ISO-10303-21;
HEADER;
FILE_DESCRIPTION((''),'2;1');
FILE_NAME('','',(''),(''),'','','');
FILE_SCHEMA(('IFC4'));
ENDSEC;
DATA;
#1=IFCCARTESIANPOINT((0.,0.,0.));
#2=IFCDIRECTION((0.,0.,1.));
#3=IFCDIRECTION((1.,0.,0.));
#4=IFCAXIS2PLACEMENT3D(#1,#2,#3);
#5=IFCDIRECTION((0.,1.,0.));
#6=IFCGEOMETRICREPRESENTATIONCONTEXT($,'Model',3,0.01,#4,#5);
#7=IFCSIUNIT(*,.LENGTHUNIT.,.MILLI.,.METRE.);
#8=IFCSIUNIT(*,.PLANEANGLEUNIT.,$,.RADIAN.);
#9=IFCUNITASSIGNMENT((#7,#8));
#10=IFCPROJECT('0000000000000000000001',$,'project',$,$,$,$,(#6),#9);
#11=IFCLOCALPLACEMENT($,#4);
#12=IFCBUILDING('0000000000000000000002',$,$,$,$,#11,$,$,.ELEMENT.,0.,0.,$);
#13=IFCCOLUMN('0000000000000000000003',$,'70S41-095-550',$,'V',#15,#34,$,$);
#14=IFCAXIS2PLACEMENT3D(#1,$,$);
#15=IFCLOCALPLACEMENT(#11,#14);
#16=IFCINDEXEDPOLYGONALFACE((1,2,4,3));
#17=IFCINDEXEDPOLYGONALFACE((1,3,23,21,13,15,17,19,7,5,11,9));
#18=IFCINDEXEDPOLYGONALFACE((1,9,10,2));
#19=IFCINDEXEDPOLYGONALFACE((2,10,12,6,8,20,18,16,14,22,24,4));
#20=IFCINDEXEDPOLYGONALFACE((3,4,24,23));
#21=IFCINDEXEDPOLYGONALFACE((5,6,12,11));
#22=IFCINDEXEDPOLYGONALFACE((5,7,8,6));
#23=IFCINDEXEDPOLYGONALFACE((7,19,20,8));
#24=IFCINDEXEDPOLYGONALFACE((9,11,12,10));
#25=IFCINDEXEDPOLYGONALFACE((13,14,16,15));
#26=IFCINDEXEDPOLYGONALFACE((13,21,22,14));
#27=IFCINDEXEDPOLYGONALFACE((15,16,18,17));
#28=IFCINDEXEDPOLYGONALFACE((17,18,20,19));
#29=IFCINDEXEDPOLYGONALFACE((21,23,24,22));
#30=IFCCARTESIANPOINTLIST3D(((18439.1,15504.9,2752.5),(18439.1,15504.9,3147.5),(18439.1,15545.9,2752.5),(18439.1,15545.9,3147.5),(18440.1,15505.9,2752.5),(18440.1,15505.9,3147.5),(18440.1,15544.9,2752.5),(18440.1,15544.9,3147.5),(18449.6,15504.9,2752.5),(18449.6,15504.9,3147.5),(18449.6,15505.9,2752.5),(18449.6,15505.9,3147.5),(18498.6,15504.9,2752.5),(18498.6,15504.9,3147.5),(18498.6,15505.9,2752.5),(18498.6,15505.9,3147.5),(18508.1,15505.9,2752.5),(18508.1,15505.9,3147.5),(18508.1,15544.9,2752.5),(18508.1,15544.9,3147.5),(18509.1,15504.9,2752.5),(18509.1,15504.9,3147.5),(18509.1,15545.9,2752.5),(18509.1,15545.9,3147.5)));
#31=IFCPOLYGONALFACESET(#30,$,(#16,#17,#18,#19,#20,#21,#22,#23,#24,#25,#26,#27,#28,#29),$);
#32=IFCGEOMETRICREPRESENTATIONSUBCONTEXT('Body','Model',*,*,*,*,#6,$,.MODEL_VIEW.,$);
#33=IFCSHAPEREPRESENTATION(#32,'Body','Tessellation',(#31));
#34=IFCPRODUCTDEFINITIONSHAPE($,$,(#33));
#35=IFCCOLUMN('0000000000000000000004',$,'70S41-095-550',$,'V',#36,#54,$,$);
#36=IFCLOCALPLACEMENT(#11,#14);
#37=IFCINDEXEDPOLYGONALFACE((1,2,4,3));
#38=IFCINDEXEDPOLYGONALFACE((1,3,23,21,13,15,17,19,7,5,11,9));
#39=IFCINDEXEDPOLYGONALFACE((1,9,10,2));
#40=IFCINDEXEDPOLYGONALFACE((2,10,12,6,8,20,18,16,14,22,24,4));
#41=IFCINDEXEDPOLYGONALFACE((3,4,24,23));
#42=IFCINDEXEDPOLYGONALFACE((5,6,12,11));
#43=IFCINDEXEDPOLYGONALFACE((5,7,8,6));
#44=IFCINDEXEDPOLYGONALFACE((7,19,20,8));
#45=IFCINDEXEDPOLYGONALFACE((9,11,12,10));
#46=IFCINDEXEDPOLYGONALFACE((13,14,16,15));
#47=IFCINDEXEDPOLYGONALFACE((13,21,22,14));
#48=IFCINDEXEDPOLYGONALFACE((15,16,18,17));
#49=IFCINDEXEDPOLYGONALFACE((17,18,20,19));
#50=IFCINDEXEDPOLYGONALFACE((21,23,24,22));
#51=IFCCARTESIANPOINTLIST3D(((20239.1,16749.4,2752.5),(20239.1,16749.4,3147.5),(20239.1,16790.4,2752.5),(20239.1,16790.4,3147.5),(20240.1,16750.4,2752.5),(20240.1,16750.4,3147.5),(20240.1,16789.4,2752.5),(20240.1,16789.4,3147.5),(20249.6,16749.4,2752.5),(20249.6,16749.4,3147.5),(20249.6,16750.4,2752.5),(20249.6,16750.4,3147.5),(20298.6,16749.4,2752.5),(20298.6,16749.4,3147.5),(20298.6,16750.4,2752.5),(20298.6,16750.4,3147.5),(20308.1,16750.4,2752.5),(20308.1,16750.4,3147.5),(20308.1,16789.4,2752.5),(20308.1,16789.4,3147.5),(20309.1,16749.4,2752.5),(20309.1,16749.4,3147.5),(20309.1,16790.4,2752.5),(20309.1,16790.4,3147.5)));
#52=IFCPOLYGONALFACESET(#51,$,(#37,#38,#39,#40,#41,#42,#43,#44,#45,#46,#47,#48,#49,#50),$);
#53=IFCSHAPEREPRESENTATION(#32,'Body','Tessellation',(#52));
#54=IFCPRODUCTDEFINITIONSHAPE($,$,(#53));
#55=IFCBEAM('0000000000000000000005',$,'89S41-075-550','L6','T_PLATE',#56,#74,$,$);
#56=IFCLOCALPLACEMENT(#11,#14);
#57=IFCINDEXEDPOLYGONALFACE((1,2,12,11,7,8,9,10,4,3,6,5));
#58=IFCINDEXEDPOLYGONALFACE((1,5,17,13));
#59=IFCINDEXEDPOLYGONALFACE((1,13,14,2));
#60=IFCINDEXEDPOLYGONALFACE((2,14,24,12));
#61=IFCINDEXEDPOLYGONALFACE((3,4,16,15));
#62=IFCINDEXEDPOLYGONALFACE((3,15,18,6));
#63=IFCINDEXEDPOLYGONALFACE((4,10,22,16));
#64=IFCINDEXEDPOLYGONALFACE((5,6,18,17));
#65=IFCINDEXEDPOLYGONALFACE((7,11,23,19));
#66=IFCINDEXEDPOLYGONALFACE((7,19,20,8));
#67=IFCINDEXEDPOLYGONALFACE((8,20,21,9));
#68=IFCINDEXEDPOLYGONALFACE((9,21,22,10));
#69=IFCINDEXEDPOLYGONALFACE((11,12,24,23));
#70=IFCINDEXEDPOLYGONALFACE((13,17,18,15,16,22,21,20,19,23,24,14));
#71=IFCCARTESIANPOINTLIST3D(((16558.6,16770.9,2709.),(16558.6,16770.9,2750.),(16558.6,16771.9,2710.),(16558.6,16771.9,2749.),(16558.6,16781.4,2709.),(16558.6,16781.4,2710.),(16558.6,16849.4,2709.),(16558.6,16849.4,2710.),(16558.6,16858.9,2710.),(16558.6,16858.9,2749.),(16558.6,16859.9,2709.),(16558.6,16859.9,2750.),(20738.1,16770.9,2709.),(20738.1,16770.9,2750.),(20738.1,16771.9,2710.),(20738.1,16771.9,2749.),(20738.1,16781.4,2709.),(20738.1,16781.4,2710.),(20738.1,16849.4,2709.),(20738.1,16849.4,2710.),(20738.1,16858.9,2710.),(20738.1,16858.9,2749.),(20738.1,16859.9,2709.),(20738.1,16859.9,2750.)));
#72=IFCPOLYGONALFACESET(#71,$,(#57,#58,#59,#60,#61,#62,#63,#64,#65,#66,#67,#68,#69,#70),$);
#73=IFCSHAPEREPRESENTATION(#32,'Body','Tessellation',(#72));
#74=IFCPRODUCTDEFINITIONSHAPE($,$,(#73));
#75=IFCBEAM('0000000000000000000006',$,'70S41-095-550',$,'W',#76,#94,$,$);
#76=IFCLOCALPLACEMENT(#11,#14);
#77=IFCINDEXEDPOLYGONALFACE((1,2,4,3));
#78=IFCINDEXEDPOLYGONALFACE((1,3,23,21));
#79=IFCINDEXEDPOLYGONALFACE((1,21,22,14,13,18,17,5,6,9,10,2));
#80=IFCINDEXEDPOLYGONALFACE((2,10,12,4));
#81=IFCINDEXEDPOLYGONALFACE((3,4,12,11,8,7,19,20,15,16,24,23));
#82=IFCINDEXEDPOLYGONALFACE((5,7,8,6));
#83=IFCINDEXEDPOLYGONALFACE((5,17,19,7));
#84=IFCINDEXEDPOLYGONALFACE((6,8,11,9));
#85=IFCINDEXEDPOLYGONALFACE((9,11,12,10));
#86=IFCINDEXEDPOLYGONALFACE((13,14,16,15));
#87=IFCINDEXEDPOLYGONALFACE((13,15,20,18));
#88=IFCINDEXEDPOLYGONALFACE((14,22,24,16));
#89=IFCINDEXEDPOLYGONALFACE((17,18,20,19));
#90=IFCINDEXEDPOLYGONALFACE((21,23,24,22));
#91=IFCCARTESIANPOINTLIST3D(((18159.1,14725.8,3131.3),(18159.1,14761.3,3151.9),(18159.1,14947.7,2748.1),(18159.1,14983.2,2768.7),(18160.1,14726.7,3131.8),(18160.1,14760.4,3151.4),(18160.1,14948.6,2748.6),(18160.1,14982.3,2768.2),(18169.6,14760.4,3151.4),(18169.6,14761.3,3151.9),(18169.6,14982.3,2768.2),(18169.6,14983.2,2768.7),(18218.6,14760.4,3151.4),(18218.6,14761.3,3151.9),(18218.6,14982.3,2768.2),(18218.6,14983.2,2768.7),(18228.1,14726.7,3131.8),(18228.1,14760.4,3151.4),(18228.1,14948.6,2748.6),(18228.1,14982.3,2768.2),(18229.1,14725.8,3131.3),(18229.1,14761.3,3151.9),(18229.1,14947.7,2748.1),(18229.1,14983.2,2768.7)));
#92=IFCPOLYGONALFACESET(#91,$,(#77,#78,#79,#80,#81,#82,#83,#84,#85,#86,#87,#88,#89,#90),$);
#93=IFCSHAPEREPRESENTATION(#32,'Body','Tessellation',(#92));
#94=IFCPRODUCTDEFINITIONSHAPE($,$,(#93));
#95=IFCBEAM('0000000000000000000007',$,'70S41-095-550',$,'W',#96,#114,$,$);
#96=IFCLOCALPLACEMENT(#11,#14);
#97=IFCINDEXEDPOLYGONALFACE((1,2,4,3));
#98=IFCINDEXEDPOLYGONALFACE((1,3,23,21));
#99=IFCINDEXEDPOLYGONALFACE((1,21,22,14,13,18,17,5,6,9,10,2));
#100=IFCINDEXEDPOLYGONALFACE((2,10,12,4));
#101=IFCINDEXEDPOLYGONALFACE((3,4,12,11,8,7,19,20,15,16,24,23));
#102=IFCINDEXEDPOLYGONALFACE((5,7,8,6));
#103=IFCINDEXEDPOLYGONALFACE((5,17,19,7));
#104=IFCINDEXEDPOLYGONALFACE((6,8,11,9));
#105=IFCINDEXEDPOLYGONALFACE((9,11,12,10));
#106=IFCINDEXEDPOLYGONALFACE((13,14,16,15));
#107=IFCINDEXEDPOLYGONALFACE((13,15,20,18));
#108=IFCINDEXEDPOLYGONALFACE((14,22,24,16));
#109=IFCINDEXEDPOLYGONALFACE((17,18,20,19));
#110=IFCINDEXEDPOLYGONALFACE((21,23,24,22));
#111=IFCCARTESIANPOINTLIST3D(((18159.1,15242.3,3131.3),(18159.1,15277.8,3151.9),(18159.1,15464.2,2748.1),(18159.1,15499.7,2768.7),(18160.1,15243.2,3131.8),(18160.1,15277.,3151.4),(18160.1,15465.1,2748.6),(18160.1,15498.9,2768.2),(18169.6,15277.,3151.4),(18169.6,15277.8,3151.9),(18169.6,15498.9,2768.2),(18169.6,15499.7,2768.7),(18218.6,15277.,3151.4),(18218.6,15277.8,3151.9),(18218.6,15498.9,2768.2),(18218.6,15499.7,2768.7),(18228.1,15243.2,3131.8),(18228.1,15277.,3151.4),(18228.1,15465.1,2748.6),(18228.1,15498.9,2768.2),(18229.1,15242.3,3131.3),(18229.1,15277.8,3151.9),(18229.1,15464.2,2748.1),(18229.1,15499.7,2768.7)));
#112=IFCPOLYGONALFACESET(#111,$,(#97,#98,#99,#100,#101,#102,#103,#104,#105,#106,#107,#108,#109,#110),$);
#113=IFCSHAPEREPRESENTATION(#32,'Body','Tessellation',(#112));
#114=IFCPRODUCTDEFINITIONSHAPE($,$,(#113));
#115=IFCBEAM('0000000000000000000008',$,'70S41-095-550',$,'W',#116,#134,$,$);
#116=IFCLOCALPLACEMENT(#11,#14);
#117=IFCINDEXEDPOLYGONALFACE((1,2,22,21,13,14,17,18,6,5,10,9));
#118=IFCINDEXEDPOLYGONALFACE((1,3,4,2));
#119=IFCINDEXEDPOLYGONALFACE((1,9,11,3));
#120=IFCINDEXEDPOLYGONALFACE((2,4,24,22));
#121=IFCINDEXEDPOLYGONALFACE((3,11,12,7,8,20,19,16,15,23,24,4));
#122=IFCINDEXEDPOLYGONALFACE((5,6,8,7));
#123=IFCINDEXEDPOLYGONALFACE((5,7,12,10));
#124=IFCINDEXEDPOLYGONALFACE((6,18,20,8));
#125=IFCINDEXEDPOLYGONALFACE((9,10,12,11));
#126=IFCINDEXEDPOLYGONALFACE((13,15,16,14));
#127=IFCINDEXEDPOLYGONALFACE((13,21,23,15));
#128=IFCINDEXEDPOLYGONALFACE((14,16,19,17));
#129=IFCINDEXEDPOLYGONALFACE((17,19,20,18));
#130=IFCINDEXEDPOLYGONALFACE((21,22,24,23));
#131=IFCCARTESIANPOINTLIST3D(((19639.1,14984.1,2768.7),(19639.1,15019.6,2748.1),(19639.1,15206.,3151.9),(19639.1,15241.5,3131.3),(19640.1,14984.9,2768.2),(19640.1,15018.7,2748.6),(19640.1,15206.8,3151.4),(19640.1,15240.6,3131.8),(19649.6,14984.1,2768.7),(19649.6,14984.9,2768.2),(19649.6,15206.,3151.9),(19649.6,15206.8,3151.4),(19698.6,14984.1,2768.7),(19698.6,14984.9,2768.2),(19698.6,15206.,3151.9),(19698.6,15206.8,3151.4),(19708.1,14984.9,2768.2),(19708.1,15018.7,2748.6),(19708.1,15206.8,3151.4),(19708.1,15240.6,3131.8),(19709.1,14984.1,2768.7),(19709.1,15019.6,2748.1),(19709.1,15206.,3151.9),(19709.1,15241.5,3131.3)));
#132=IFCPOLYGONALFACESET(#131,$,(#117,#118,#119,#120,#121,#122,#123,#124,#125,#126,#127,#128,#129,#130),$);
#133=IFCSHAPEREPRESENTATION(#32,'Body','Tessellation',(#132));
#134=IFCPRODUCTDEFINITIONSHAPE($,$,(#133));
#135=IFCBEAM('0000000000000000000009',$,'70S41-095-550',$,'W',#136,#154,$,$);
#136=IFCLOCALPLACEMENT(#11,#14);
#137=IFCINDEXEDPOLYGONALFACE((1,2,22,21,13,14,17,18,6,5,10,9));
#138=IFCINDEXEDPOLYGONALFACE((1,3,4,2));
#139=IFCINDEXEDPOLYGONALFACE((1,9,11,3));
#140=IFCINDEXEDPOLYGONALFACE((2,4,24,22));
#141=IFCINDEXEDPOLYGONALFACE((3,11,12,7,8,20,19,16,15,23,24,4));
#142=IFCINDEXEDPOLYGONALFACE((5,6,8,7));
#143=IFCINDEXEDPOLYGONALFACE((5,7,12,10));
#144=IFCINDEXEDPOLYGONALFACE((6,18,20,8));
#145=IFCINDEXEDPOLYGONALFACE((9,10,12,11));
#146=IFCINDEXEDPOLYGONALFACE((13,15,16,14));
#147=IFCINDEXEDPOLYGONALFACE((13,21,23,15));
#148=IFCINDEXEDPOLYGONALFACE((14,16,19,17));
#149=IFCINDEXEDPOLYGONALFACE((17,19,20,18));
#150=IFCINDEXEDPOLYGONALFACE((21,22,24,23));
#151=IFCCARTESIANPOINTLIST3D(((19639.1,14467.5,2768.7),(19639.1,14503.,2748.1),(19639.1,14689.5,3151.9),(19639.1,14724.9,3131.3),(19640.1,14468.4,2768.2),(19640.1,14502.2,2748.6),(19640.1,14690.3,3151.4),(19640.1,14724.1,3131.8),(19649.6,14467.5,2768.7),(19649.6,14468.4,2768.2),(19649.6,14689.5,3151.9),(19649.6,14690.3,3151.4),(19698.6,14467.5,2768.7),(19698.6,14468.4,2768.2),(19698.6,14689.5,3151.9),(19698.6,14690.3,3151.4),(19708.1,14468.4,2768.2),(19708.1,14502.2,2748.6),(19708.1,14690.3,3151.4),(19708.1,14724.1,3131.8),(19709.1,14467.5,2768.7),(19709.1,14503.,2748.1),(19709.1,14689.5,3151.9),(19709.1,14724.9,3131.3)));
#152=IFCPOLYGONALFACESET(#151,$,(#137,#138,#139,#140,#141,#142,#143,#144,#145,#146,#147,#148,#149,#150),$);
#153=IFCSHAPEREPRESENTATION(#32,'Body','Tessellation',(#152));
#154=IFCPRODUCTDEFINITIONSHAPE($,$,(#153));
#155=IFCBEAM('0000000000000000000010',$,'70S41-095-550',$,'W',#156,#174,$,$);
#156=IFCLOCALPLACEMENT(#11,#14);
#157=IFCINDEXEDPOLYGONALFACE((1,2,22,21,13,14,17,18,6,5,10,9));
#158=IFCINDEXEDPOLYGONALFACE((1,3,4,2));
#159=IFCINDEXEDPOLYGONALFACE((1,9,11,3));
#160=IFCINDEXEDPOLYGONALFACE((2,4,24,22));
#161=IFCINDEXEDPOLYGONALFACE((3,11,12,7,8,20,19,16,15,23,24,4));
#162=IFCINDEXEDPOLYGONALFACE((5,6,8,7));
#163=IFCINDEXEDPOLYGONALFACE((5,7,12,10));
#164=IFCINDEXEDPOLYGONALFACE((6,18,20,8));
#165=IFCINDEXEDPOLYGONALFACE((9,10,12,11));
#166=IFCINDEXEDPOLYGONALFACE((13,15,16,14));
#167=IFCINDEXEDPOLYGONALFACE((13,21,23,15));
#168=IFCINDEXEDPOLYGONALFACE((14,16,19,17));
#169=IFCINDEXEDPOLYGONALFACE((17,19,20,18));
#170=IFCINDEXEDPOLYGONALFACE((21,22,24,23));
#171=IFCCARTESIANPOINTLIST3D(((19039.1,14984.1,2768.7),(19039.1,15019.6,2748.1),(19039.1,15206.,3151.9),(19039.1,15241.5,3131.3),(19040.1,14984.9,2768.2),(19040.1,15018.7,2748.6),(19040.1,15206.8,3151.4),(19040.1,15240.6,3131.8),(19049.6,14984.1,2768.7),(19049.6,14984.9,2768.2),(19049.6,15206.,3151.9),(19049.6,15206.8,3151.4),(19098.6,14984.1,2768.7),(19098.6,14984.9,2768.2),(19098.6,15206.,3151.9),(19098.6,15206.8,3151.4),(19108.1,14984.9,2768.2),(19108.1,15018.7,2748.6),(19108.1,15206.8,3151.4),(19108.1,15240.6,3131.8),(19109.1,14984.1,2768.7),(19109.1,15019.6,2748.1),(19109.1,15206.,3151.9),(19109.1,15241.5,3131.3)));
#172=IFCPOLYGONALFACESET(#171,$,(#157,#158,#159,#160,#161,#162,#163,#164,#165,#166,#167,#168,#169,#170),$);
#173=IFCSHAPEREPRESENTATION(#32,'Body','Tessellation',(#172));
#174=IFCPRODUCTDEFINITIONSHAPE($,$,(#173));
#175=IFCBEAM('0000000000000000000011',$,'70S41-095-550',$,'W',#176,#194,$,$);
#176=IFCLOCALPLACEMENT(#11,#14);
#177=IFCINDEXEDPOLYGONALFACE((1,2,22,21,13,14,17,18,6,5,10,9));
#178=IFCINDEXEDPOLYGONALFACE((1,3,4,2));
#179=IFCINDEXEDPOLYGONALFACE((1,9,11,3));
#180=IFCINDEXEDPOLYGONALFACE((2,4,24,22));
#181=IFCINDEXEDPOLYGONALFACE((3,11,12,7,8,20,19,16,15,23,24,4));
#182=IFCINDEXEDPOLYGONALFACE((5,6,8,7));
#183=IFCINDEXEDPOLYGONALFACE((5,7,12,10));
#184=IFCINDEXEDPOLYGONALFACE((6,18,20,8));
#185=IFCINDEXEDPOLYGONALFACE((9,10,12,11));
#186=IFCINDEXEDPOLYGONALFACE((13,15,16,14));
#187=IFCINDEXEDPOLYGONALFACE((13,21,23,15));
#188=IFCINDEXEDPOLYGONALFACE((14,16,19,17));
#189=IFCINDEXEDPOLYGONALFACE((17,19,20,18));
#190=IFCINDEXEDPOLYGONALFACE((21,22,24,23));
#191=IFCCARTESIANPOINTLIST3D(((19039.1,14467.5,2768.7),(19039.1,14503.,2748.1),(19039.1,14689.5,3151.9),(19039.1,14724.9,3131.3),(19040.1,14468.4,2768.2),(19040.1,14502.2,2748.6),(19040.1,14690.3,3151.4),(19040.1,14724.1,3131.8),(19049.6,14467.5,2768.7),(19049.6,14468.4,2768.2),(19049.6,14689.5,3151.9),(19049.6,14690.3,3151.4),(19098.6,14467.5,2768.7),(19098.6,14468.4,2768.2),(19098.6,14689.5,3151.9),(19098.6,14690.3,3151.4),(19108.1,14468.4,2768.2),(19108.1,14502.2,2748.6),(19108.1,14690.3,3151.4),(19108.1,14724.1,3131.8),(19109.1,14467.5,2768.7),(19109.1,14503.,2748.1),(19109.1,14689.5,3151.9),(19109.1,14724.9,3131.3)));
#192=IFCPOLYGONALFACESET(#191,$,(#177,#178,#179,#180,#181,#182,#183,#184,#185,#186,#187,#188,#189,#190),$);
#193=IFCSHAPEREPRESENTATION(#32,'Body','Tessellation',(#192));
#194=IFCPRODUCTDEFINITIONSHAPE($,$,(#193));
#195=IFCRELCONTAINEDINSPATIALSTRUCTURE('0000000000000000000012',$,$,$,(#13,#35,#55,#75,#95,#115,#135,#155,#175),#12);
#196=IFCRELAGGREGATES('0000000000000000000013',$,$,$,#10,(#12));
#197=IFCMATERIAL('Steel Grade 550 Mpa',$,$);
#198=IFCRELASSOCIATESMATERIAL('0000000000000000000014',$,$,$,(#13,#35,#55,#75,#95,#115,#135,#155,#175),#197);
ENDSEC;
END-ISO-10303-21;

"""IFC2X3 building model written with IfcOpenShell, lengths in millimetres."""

from ifc_helpers import new_model, si_unit, direction, frame, origin, origin_with_axes, origin_2d_with_axis, place, context, subcontext, project, spatial, c_section, extrude, source, transform, mapped, material, element, save


model = new_model("IFC2X3")

# Units and contexts
model_context = context("Model", 3, precision=0.01, world=origin_with_axes(), true_north=direction((0.0, 1.0, 0.0)))
body_context = subcontext(model_context, "Body", "Model", "MODEL_VIEW")
ifc_project = project(units=[si_unit("LENGTHUNIT", "METRE", prefix="MILLI"), si_unit("PLANEANGLEUNIT", "RADIAN")], contexts=[model_context])

# Building
building_placement = place(None, origin_with_axes())
building = spatial("IfcBuilding", under=ifc_project, at=building_placement, CompositionType="ELEMENT", ElevationOfRefHeight=0.0, ElevationOfTerrain=0.0)

# Columns
ifc_material = material(Name="Steel Grade 550 Mpa")
shared_shape_1 = source(origin(), body_context, "Body", "SweptSolid", [
    extrude(c_section(Depth=70.0, Width=41.0, WallThickness=1.0, Girth=10.5, at=origin_2d_with_axis()), origin_with_axes(), (0.0, 0.0, 1.0), 395.0),
])
column_1_placement = place(None, frame((18474.1, 15525.4, 2752.5), z_axis=(0.0, 0.0, 1.0), x_axis=(0.0, -1.0, 0.0)))
element("IfcColumn", 1, at=column_1_placement, inside=building, material=ifc_material, Name="70S41-095-550", ObjectType="V", context=body_context, shape_type="MappedRepresentation", body=[
    mapped(shared_shape_1, transform((0.0, 0.0, 0.0), scale=1.0)),
])
shared_shape_2 = source(origin(), body_context, "Body", "SweptSolid", [
    extrude(c_section(Depth=70.0, Width=41.0, WallThickness=1.0, Girth=10.5, at=origin_2d_with_axis()), origin_with_axes(), (0.0, 0.0, 1.0), 395.0),
])
column_2_placement = place(None, frame((20274.1, 16769.9, 2752.5), z_axis=(0.0, 0.0, 1.0), x_axis=(0.0, -1.0, 0.0)))
element("IfcColumn", 2, at=column_2_placement, inside=building, material=ifc_material, Name="70S41-095-550", ObjectType="V", context=body_context, shape_type="MappedRepresentation", body=[
    mapped(shared_shape_2, transform((0.0, 0.0, 0.0), scale=1.0)),
])

# Beams
shared_shape_3 = source(origin(), body_context, "Body", "SweptSolid", [
    extrude(c_section(Depth=89.0, Width=41.0, WallThickness=1.0, Girth=10.5, at=origin_2d_with_axis()), origin_with_axes(), (0.0, 0.0, 1.0), 4179.5),
])
beam_1_placement = place(None, frame((20738.1, 16815.4, 2729.5), z_axis=(-1.0, 0.0, 0.0), x_axis=(0.0, 0.0, -1.0)))
element("IfcBeam", 3, at=beam_1_placement, inside=building, material=ifc_material, Name="89S41-075-550", Description="L6", ObjectType="T_PLATE", context=body_context, shape_type="MappedRepresentation", body=[
    mapped(shared_shape_3, transform((0.0, 0.0, 0.0), scale=1.0)),
])
shared_shape_4 = source(origin(), body_context, "Body", "SweptSolid", [
    extrude(c_section(Depth=70.0, Width=41.0, WallThickness=1.0, Girth=10.5, at=origin_2d_with_axis()), origin_with_axes(), (0.0, 0.0, 1.0), 442.8),
])
beam_2_placement = place(None, frame((18194.1, 14965.5, 2758.4), z_axis=(0.0, -0.501095, 0.865392), x_axis=(0.0, 0.865392, 0.501095)))
element("IfcBeam", 4, at=beam_2_placement, inside=building, material=ifc_material, Name="70S41-095-550", ObjectType="W", context=body_context, shape_type="MappedRepresentation", body=[
    mapped(shared_shape_4, transform((0.0, 0.0, 0.0), scale=1.0)),
])
shared_shape_5 = source(origin(), body_context, "Body", "SweptSolid", [
    extrude(c_section(Depth=70.0, Width=41.0, WallThickness=1.0, Girth=10.5, at=origin_2d_with_axis()), origin_with_axes(), (0.0, 0.0, 1.0), 442.8),
])
beam_3_placement = place(None, frame((18194.1, 15482.0, 2758.4), z_axis=(0.0, -0.501095, 0.865392), x_axis=(0.0, 0.865392, 0.501095)))
element("IfcBeam", 5, at=beam_3_placement, inside=building, material=ifc_material, Name="70S41-095-550", ObjectType="W", context=body_context, shape_type="MappedRepresentation", body=[
    mapped(shared_shape_5, transform((0.0, 0.0, 0.0), scale=1.0)),
])
shared_shape_6 = source(origin(), body_context, "Body", "SweptSolid", [
    extrude(c_section(Depth=70.0, Width=41.0, WallThickness=1.0, Girth=10.5, at=origin_2d_with_axis()), origin_with_axes(), (0.0, 0.0, 1.0), 442.8),
])
beam_4_placement = place(None, frame((19674.1, 15001.8, 2758.4), z_axis=(0.0, 0.501095, 0.865392), x_axis=(0.0, -0.865392, 0.501095)))
element("IfcBeam", 6, at=beam_4_placement, inside=building, material=ifc_material, Name="70S41-095-550", ObjectType="W", context=body_context, shape_type="MappedRepresentation", body=[
    mapped(shared_shape_6, transform((0.0, 0.0, 0.0), scale=1.0)),
])
shared_shape_7 = source(origin(), body_context, "Body", "SweptSolid", [
    extrude(c_section(Depth=70.0, Width=41.0, WallThickness=1.0, Girth=10.5, at=origin_2d_with_axis()), origin_with_axes(), (0.0, 0.0, 1.0), 442.8),
])
beam_5_placement = place(None, frame((19674.1, 14485.3, 2758.4), z_axis=(0.0, 0.501095, 0.865392), x_axis=(0.0, -0.865392, 0.501095)))
element("IfcBeam", 7, at=beam_5_placement, inside=building, material=ifc_material, Name="70S41-095-550", ObjectType="W", context=body_context, shape_type="MappedRepresentation", body=[
    mapped(shared_shape_7, transform((0.0, 0.0, 0.0), scale=1.0)),
])
shared_shape_8 = source(origin(), body_context, "Body", "SweptSolid", [
    extrude(c_section(Depth=70.0, Width=41.0, WallThickness=1.0, Girth=10.5, at=origin_2d_with_axis()), origin_with_axes(), (0.0, 0.0, 1.0), 442.8),
])
beam_6_placement = place(None, frame((19074.1, 15001.8, 2758.4), z_axis=(0.0, 0.501095, 0.865392), x_axis=(0.0, -0.865392, 0.501095)))
element("IfcBeam", 8, at=beam_6_placement, inside=building, material=ifc_material, Name="70S41-095-550", ObjectType="W", context=body_context, shape_type="MappedRepresentation", body=[
    mapped(shared_shape_8, transform((0.0, 0.0, 0.0), scale=1.0)),
])
shared_shape_9 = source(origin(), body_context, "Body", "SweptSolid", [
    extrude(c_section(Depth=70.0, Width=41.0, WallThickness=1.0, Girth=10.5, at=origin_2d_with_axis()), origin_with_axes(), (0.0, 0.0, 1.0), 442.8),
])
beam_7_placement = place(None, frame((19074.1, 14485.3, 2758.4), z_axis=(0.0, 0.501095, 0.865392), x_axis=(0.0, -0.865392, 0.501095)))
element("IfcBeam", 9, at=beam_7_placement, inside=building, material=ifc_material, Name="70S41-095-550", ObjectType="W", context=body_context, shape_type="MappedRepresentation", body=[
    mapped(shared_shape_9, transform((0.0, 0.0, 0.0), scale=1.0)),
])

save(model, "model.ifc")
